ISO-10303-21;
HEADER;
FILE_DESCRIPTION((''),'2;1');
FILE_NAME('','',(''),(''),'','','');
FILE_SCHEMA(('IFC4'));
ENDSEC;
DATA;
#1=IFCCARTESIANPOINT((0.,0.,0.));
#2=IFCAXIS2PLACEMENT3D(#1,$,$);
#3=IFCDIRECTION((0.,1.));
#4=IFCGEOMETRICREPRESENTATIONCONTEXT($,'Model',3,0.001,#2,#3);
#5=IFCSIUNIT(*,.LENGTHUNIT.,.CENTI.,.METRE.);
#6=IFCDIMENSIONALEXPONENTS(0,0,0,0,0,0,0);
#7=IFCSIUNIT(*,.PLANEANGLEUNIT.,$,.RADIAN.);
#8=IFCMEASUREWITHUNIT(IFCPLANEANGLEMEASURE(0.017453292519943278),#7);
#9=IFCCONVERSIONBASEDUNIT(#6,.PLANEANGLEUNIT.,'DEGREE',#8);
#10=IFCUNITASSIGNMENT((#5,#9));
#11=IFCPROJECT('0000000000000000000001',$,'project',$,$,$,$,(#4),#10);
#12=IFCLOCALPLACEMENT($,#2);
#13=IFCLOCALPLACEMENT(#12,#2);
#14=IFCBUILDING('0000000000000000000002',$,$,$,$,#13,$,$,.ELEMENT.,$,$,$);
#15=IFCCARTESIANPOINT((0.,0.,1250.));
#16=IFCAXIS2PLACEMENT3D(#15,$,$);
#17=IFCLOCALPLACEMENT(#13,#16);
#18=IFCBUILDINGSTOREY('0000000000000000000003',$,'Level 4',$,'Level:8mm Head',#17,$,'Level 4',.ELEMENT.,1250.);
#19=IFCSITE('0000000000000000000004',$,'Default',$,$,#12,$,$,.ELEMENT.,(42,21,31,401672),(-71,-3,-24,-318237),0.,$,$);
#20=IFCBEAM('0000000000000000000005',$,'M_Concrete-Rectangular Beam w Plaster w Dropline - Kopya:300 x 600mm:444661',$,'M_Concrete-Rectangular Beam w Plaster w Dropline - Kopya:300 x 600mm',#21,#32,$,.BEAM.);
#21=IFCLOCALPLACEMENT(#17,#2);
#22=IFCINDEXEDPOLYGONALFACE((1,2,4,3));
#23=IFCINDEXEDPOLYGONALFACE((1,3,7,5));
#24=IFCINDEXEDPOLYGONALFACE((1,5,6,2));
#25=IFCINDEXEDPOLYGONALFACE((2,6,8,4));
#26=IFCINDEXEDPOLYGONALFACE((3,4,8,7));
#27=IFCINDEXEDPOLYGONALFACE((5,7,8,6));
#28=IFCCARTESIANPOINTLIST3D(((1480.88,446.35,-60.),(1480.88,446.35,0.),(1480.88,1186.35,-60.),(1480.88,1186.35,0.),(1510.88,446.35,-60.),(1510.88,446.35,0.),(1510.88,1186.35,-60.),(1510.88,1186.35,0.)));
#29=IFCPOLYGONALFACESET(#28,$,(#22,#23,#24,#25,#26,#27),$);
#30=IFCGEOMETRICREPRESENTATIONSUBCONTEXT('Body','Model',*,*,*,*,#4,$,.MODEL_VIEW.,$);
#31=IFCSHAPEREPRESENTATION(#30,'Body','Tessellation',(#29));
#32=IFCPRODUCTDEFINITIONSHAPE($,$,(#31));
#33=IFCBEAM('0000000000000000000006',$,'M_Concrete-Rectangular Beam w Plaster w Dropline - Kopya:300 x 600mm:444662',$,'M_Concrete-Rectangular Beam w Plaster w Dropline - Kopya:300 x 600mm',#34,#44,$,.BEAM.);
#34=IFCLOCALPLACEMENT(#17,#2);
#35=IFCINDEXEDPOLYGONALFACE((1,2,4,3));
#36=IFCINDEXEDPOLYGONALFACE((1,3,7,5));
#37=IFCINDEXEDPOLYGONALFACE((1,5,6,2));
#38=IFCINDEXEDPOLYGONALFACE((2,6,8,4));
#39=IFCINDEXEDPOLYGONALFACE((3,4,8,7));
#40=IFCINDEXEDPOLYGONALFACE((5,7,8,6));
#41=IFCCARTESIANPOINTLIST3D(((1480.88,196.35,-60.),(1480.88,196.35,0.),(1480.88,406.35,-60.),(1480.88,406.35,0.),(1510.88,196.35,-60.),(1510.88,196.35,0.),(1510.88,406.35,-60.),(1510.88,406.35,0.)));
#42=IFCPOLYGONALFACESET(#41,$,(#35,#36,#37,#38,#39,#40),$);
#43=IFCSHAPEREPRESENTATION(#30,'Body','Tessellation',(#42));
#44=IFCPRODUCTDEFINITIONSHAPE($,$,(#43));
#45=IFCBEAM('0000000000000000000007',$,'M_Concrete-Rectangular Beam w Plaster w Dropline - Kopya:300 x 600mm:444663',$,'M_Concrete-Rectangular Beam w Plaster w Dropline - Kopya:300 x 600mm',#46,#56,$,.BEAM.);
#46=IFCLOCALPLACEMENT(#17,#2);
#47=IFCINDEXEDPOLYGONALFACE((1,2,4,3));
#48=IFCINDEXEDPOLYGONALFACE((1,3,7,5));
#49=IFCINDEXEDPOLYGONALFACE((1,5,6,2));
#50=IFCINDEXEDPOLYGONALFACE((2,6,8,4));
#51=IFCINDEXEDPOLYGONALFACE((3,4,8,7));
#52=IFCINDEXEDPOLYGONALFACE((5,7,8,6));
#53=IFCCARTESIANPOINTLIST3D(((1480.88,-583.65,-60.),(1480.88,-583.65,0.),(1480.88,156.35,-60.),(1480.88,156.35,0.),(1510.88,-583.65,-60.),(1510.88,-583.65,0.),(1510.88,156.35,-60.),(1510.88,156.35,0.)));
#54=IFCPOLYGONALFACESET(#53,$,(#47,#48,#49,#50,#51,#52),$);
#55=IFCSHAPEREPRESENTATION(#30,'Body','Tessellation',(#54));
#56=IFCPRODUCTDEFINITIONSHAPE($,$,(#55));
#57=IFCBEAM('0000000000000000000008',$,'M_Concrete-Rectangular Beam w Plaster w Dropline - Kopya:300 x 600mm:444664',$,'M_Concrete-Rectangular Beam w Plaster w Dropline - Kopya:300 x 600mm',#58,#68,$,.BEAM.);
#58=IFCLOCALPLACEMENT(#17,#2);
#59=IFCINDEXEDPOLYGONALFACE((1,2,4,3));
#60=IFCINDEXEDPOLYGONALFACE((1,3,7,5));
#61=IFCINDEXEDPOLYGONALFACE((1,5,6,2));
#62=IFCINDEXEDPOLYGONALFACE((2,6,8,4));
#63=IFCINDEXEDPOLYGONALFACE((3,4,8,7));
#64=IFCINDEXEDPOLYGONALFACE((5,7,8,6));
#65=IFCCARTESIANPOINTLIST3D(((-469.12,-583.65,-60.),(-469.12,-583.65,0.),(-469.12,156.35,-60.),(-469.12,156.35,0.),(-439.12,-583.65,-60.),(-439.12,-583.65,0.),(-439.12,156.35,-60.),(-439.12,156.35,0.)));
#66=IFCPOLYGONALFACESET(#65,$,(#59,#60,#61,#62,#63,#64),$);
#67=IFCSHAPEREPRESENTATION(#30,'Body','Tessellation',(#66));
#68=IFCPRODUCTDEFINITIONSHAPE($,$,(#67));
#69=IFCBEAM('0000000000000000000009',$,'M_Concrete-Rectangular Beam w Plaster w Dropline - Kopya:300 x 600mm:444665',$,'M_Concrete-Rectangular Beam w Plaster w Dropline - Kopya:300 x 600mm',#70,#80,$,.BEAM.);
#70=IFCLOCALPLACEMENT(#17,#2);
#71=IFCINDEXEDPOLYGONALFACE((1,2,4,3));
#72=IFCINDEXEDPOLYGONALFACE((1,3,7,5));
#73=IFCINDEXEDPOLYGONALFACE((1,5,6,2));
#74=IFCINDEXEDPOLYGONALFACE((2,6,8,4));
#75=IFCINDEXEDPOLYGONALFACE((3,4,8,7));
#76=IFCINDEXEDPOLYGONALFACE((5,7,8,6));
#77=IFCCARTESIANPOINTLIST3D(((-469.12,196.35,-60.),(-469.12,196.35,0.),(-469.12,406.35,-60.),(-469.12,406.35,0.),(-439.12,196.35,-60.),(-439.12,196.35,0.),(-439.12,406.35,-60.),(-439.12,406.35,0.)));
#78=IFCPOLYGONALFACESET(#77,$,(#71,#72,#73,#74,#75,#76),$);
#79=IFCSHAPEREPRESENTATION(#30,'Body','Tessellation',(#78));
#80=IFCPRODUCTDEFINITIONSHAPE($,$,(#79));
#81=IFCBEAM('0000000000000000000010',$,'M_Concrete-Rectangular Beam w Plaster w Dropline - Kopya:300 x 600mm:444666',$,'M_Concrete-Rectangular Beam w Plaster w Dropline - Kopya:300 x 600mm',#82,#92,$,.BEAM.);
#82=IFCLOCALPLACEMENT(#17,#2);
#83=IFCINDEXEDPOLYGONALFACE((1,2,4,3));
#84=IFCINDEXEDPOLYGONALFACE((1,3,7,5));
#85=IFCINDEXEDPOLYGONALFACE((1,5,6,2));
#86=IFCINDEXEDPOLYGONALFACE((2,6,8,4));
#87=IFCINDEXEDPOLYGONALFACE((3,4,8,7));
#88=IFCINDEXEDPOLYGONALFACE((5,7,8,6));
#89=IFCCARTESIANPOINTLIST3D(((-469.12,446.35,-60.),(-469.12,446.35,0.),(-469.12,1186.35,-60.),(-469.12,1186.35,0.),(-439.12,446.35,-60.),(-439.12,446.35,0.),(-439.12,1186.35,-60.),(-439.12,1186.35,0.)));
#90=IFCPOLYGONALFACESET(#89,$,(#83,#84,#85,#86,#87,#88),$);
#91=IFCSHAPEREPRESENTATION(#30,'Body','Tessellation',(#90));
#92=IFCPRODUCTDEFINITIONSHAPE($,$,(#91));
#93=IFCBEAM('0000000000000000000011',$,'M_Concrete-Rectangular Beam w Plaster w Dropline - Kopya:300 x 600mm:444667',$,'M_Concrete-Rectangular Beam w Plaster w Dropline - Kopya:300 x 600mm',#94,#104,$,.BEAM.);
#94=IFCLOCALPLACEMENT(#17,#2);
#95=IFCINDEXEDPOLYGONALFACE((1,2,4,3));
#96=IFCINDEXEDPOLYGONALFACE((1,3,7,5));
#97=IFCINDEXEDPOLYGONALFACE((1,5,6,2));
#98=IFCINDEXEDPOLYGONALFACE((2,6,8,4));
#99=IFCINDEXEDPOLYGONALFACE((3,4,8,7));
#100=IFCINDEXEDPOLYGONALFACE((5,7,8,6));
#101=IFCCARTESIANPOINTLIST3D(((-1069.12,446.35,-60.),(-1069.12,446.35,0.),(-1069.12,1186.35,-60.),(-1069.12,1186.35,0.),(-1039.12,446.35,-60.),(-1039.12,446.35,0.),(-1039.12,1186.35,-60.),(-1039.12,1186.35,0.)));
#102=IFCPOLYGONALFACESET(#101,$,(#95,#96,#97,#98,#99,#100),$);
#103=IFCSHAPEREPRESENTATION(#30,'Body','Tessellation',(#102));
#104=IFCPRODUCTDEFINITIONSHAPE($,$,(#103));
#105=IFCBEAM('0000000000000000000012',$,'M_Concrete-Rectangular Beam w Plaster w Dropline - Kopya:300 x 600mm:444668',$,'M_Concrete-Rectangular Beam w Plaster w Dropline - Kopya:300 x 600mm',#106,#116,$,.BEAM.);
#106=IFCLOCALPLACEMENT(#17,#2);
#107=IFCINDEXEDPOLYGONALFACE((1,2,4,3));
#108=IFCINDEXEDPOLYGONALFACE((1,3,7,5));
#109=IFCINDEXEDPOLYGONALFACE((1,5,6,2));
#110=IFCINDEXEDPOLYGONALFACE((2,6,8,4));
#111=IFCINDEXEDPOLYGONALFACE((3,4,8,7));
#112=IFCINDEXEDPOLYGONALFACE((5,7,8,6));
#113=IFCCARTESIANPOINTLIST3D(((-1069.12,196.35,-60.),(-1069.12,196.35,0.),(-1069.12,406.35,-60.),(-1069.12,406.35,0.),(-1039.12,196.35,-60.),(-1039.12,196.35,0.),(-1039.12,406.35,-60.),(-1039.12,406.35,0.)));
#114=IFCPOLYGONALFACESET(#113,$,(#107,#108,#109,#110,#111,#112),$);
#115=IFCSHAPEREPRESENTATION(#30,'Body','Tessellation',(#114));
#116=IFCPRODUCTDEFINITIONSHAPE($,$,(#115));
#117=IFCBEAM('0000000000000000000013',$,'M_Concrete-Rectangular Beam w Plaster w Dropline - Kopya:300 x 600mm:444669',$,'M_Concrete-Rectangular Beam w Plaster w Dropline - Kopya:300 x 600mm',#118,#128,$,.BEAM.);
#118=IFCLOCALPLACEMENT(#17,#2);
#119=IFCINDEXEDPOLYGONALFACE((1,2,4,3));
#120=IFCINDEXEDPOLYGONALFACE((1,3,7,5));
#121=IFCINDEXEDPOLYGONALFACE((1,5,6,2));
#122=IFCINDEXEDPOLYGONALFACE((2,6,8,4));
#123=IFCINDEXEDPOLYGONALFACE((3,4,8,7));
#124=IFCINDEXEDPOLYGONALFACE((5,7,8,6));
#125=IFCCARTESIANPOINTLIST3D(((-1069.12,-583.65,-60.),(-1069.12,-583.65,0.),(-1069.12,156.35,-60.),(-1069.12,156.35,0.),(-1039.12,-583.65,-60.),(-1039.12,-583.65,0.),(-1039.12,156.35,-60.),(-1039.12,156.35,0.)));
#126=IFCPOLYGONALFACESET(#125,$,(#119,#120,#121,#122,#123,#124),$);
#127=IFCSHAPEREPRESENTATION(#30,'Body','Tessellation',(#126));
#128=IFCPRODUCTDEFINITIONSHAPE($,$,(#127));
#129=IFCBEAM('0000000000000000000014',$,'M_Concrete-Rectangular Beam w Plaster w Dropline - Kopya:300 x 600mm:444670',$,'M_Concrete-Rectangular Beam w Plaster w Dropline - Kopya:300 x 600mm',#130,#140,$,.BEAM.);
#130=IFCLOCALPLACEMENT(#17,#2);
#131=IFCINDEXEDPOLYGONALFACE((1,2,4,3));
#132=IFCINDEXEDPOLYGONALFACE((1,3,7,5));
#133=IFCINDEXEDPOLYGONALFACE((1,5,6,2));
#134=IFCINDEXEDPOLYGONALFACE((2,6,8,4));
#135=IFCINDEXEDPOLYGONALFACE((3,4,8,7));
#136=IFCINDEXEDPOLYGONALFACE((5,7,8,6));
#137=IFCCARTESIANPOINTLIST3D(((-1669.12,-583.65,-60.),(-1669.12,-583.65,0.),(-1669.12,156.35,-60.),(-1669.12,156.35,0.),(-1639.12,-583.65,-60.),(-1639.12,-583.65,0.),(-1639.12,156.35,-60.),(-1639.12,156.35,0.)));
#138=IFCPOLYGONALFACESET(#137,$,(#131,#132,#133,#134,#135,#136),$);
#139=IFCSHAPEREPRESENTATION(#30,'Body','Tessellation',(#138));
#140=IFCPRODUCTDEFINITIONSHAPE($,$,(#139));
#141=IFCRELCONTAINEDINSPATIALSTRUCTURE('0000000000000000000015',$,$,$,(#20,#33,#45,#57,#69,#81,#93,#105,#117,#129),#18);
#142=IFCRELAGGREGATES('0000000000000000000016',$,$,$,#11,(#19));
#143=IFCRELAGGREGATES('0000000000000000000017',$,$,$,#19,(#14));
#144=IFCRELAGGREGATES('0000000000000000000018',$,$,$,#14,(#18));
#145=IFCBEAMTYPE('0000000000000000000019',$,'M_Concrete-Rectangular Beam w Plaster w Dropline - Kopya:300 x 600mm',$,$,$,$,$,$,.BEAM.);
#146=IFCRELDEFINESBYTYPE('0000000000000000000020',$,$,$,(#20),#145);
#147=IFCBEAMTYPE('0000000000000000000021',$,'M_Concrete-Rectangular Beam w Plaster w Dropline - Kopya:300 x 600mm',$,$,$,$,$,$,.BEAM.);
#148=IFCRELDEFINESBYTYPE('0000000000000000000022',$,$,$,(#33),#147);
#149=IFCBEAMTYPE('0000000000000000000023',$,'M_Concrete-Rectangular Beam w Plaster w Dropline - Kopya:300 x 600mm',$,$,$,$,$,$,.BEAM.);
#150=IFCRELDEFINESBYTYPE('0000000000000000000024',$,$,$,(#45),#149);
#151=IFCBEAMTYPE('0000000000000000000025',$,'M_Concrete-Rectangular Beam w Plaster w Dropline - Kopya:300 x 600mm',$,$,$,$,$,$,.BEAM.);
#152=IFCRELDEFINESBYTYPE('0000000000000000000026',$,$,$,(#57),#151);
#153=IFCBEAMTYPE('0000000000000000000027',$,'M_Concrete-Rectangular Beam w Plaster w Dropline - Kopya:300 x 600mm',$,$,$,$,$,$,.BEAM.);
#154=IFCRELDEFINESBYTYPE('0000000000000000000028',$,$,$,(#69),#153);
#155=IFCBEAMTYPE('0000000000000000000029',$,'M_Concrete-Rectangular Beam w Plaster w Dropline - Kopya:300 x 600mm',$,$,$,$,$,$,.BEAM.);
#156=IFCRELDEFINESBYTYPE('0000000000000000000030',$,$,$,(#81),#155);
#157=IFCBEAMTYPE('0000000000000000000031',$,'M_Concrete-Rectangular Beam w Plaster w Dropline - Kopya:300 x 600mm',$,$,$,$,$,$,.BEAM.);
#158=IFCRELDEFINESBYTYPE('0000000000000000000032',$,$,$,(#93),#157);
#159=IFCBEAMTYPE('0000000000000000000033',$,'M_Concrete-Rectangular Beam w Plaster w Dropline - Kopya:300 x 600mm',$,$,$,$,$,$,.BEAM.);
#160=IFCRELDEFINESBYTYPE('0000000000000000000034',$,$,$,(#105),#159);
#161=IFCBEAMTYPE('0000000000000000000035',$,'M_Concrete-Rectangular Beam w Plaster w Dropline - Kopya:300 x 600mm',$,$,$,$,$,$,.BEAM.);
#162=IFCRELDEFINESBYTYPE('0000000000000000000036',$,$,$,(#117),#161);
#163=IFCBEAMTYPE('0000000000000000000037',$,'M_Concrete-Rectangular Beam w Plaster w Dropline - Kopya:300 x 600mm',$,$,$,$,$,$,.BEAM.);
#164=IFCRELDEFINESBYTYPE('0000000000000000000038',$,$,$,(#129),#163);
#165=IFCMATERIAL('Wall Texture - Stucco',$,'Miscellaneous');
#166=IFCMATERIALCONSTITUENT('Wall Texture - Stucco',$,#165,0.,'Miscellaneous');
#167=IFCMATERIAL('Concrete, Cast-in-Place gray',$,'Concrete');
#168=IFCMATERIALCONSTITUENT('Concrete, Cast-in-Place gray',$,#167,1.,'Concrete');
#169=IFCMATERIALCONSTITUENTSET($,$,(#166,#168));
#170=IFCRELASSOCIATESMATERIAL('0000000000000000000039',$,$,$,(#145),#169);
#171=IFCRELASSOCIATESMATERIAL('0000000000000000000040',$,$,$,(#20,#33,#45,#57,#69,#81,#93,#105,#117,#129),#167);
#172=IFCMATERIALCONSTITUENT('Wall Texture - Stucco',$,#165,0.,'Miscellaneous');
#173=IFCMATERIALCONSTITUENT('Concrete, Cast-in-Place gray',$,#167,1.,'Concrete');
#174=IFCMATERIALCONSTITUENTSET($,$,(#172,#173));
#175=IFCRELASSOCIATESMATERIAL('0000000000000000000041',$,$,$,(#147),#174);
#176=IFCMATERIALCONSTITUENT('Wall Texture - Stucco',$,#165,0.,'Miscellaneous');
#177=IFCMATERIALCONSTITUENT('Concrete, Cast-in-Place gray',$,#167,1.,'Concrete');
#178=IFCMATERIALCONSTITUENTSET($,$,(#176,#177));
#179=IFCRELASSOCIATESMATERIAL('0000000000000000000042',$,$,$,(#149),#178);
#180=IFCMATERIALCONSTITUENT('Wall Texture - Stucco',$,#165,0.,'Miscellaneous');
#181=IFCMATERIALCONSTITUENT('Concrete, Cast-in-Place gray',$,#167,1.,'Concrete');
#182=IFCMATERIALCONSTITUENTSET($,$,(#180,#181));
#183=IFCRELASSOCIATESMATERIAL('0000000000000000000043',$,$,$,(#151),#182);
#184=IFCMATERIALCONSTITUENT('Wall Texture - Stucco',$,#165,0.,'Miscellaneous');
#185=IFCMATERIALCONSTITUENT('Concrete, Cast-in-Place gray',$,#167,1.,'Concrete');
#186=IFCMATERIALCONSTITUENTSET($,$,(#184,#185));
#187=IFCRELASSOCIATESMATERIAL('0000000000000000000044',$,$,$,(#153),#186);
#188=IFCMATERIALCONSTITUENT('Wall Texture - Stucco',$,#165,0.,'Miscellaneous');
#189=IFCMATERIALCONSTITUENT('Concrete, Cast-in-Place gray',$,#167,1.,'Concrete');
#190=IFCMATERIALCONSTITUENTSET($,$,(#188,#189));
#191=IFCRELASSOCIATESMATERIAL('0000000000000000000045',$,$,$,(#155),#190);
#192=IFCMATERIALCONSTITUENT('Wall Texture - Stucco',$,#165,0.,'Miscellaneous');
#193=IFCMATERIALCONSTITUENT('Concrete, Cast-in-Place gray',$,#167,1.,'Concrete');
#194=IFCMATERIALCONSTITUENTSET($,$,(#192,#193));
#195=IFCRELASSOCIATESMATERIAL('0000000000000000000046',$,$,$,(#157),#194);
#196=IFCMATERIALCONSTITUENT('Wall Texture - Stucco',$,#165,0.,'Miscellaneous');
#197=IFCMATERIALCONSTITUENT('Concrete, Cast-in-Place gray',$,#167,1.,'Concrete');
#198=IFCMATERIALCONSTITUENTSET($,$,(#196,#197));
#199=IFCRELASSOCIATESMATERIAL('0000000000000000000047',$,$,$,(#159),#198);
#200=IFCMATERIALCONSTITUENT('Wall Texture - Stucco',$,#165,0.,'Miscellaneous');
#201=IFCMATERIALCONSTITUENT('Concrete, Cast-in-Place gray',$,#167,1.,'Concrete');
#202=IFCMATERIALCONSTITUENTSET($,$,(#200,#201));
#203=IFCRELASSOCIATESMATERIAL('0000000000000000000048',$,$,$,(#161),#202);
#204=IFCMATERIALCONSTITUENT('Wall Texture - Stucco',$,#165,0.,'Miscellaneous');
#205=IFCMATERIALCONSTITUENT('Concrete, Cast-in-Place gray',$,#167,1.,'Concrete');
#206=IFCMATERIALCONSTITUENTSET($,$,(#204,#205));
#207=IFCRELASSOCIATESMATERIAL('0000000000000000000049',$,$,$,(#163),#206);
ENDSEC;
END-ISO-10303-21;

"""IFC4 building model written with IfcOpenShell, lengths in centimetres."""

from ifc_helpers import new_model, entity, si_unit, converted_unit, direction, frame, origin, place, context, subcontext, project, spatial, indexed_curve, outline, extrude, source, transform, mapped, material, constituent, constituent_set, type_object, type_shapes, element, save


model = new_model("IFC4")

# Units and contexts
model_context = context("Model", 3, precision=0.001, world=origin(), true_north=direction((0.0, 1.0)))
body_context = subcontext(model_context, "Body", "Model", "MODEL_VIEW")
ifc_project = project(units=[si_unit("LENGTHUNIT", "METRE", prefix="CENTI"), converted_unit("PLANEANGLEUNIT", "DEGREE", entity("IfcPlaneAngleMeasure", 0.017453292519943278), si_unit("PLANEANGLEUNIT", "RADIAN"), dimensions=[0, 0, 0, 0, 0, 0, 0])], contexts=[model_context])

# Site, building, storey
site_placement = place(None, origin())
site = spatial("IfcSite", under=ifc_project, at=site_placement, Name="Default", CompositionType="ELEMENT", RefLatitude=(42, 21, 31, 401672), RefLongitude=(-71, -3, -24, -318237), RefElevation=0.0)
building_placement = place(site_placement, origin())
building = spatial("IfcBuilding", under=site, at=building_placement, CompositionType="ELEMENT")
storey_placement = place(building_placement, frame((0.0, 0.0, 1250.0)))
storey = spatial("IfcBuildingStorey", under=building, at=storey_placement, Name="Level 4", ObjectType="Level:8mm Head", LongName="Level 4", CompositionType="ELEMENT", Elevation=1250.0)

# Shared definitions
ifc_material_1 = material(Name="Concrete, Cast-in-Place gray", Category="Concrete")

# Beams
ifc_material_2 = material(Name="Wall Texture - Stucco", Category="Miscellaneous")
ifc_constituent_1 = constituent(ifc_material_2, Name="Wall Texture - Stucco", Category="Miscellaneous", fraction=0.0)
ifc_constituent_2 = constituent(ifc_material_1, Name="Concrete, Cast-in-Place gray", Category="Concrete", fraction=1.0)
ifc_constituent_set_1 = constituent_set(constituents=[ifc_constituent_1, ifc_constituent_2])
beam_type_1 = type_object("IfcBeamType", Name="M_Concrete-Rectangular Beam w Plaster w Dropline - Kopya:300 x 600mm", PredefinedType="BEAM", material=ifc_constituent_set_1)
shared_shape_1 = source(origin(), body_context, "Body", "SweptSolid", [
    extrude(outline(indexed_curve([(-15.0, -30.0), (15.0, -30.0), (15.0, 30.0), (-15.0, 30.0), (-15.0, -30.0)], self_intersect=False)), frame((1495.88, 1186.35, 1220.0), z_axis=(0.0, -1.0, 0.0), x_axis=(-1.0, 0.0, 0.0)), (0.0, 0.0, 1.0), 740.0),
])
type_shapes(beam_type_1, [shared_shape_1])
beam_1_placement = place(storey_placement, frame((0.0, 0.0, -1250.0)))
element("IfcBeam", 1, at=beam_1_placement, inside=storey, type_object=beam_type_1, material=ifc_material_1, Name="M_Concrete-Rectangular Beam w Plaster w Dropline - Kopya:300 x 600mm:444661", ObjectType="M_Concrete-Rectangular Beam w Plaster w Dropline - Kopya:300 x 600mm", PredefinedType="BEAM", context=body_context, shape_type="MappedRepresentation", body=[
    mapped(shared_shape_1, transform((0.0, 0.0, 0.0), scale=1.0)),
])
ifc_constituent_3 = constituent(ifc_material_2, Name="Wall Texture - Stucco", Category="Miscellaneous", fraction=0.0)
ifc_constituent_4 = constituent(ifc_material_1, Name="Concrete, Cast-in-Place gray", Category="Concrete", fraction=1.0)
ifc_constituent_set_2 = constituent_set(constituents=[ifc_constituent_3, ifc_constituent_4])
beam_type_2 = type_object("IfcBeamType", Name="M_Concrete-Rectangular Beam w Plaster w Dropline - Kopya:300 x 600mm", PredefinedType="BEAM", material=ifc_constituent_set_2)
shared_shape_2 = source(origin(), body_context, "Body", "SweptSolid", [
    extrude(outline(indexed_curve([(-15.0, -30.0), (15.0, -30.0), (15.0, 30.0), (-15.0, 30.0), (-15.0, -30.0)], self_intersect=False)), frame((1495.88, 406.35, 1220.0), z_axis=(0.0, -1.0, 0.0), x_axis=(-1.0, 0.0, 0.0)), (0.0, 0.0, 1.0), 210.0),
])
type_shapes(beam_type_2, [shared_shape_2])
beam_2_placement = place(storey_placement, frame((0.0, 0.0, -1250.0)))
element("IfcBeam", 2, at=beam_2_placement, inside=storey, type_object=beam_type_2, material=ifc_material_1, Name="M_Concrete-Rectangular Beam w Plaster w Dropline - Kopya:300 x 600mm:444662", ObjectType="M_Concrete-Rectangular Beam w Plaster w Dropline - Kopya:300 x 600mm", PredefinedType="BEAM", context=body_context, shape_type="MappedRepresentation", body=[
    mapped(shared_shape_2, transform((0.0, 0.0, 0.0), scale=1.0)),
])
ifc_constituent_5 = constituent(ifc_material_2, Name="Wall Texture - Stucco", Category="Miscellaneous", fraction=0.0)
ifc_constituent_6 = constituent(ifc_material_1, Name="Concrete, Cast-in-Place gray", Category="Concrete", fraction=1.0)
ifc_constituent_set_3 = constituent_set(constituents=[ifc_constituent_5, ifc_constituent_6])
beam_type_3 = type_object("IfcBeamType", Name="M_Concrete-Rectangular Beam w Plaster w Dropline - Kopya:300 x 600mm", PredefinedType="BEAM", material=ifc_constituent_set_3)
shared_shape_3 = source(origin(), body_context, "Body", "SweptSolid", [
    extrude(outline(indexed_curve([(-15.0, -30.0), (15.0, -30.0), (15.0, 30.0), (-15.0, 30.0), (-15.0, -30.0)], self_intersect=False)), frame((1495.88, 156.35, 1220.0), z_axis=(0.0, -1.0, 0.0), x_axis=(-1.0, 0.0, 0.0)), (0.0, 0.0, 1.0), 740.0),
])
type_shapes(beam_type_3, [shared_shape_3])
beam_3_placement = place(storey_placement, frame((0.0, 0.0, -1250.0)))
element("IfcBeam", 3, at=beam_3_placement, inside=storey, type_object=beam_type_3, material=ifc_material_1, Name="M_Concrete-Rectangular Beam w Plaster w Dropline - Kopya:300 x 600mm:444663", ObjectType="M_Concrete-Rectangular Beam w Plaster w Dropline - Kopya:300 x 600mm", PredefinedType="BEAM", context=body_context, shape_type="MappedRepresentation", body=[
    mapped(shared_shape_3, transform((0.0, 0.0, 0.0), scale=1.0)),
])
ifc_constituent_7 = constituent(ifc_material_2, Name="Wall Texture - Stucco", Category="Miscellaneous", fraction=0.0)
ifc_constituent_8 = constituent(ifc_material_1, Name="Concrete, Cast-in-Place gray", Category="Concrete", fraction=1.0)
ifc_constituent_set_4 = constituent_set(constituents=[ifc_constituent_7, ifc_constituent_8])
beam_type_4 = type_object("IfcBeamType", Name="M_Concrete-Rectangular Beam w Plaster w Dropline - Kopya:300 x 600mm", PredefinedType="BEAM", material=ifc_constituent_set_4)
shared_shape_4 = source(origin(), body_context, "Body", "SweptSolid", [
    extrude(outline(indexed_curve([(-15.0, -30.0), (15.0, -30.0), (15.0, 30.0), (-15.0, 30.0), (-15.0, -30.0)], self_intersect=False)), frame((-454.12, -583.65, 1220.0), z_axis=(0.0, 1.0, 0.0), x_axis=(-1.0, 0.0, 0.0)), (0.0, 0.0, 1.0), 740.0),
])
type_shapes(beam_type_4, [shared_shape_4])
beam_4_placement = place(storey_placement, frame((0.0, 0.0, -1250.0)))
element("IfcBeam", 4, at=beam_4_placement, inside=storey, type_object=beam_type_4, material=ifc_material_1, Name="M_Concrete-Rectangular Beam w Plaster w Dropline - Kopya:300 x 600mm:444664", ObjectType="M_Concrete-Rectangular Beam w Plaster w Dropline - Kopya:300 x 600mm", PredefinedType="BEAM", context=body_context, shape_type="MappedRepresentation", body=[
    mapped(shared_shape_4, transform((0.0, 0.0, 0.0), scale=1.0)),
])
ifc_constituent_9 = constituent(ifc_material_2, Name="Wall Texture - Stucco", Category="Miscellaneous", fraction=0.0)
ifc_constituent_10 = constituent(ifc_material_1, Name="Concrete, Cast-in-Place gray", Category="Concrete", fraction=1.0)
ifc_constituent_set_5 = constituent_set(constituents=[ifc_constituent_9, ifc_constituent_10])
beam_type_5 = type_object("IfcBeamType", Name="M_Concrete-Rectangular Beam w Plaster w Dropline - Kopya:300 x 600mm", PredefinedType="BEAM", material=ifc_constituent_set_5)
shared_shape_5 = source(origin(), body_context, "Body", "SweptSolid", [
    extrude(outline(indexed_curve([(-15.0, -30.0), (15.0, -30.0), (15.0, 30.0), (-15.0, 30.0), (-15.0, -30.0)], self_intersect=False)), frame((-454.12, 196.35, 1220.0), z_axis=(0.0, 1.0, 0.0), x_axis=(-1.0, 0.0, 0.0)), (0.0, 0.0, 1.0), 210.0),
])
type_shapes(beam_type_5, [shared_shape_5])
beam_5_placement = place(storey_placement, frame((0.0, 0.0, -1250.0)))
element("IfcBeam", 5, at=beam_5_placement, inside=storey, type_object=beam_type_5, material=ifc_material_1, Name="M_Concrete-Rectangular Beam w Plaster w Dropline - Kopya:300 x 600mm:444665", ObjectType="M_Concrete-Rectangular Beam w Plaster w Dropline - Kopya:300 x 600mm", PredefinedType="BEAM", context=body_context, shape_type="MappedRepresentation", body=[
    mapped(shared_shape_5, transform((0.0, 0.0, 0.0), scale=1.0)),
])
ifc_constituent_11 = constituent(ifc_material_2, Name="Wall Texture - Stucco", Category="Miscellaneous", fraction=0.0)
ifc_constituent_12 = constituent(ifc_material_1, Name="Concrete, Cast-in-Place gray", Category="Concrete", fraction=1.0)
ifc_constituent_set_6 = constituent_set(constituents=[ifc_constituent_11, ifc_constituent_12])
beam_type_6 = type_object("IfcBeamType", Name="M_Concrete-Rectangular Beam w Plaster w Dropline - Kopya:300 x 600mm", PredefinedType="BEAM", material=ifc_constituent_set_6)
shared_shape_6 = source(origin(), body_context, "Body", "SweptSolid", [
    extrude(outline(indexed_curve([(-15.0, -30.0), (15.0, -30.0), (15.0, 30.0), (-15.0, 30.0), (-15.0, -30.0)], self_intersect=False)), frame((-454.12, 446.35, 1220.0), z_axis=(0.0, 1.0, 0.0), x_axis=(-1.0, 0.0, 0.0)), (0.0, 0.0, 1.0), 740.0),
])
type_shapes(beam_type_6, [shared_shape_6])
beam_6_placement = place(storey_placement, frame((0.0, 0.0, -1250.0)))
element("IfcBeam", 6, at=beam_6_placement, inside=storey, type_object=beam_type_6, material=ifc_material_1, Name="M_Concrete-Rectangular Beam w Plaster w Dropline - Kopya:300 x 600mm:444666", ObjectType="M_Concrete-Rectangular Beam w Plaster w Dropline - Kopya:300 x 600mm", PredefinedType="BEAM", context=body_context, shape_type="MappedRepresentation", body=[
    mapped(shared_shape_6, transform((0.0, 0.0, 0.0), scale=1.0)),
])
ifc_constituent_13 = constituent(ifc_material_2, Name="Wall Texture - Stucco", Category="Miscellaneous", fraction=0.0)
ifc_constituent_14 = constituent(ifc_material_1, Name="Concrete, Cast-in-Place gray", Category="Concrete", fraction=1.0)
ifc_constituent_set_7 = constituent_set(constituents=[ifc_constituent_13, ifc_constituent_14])
beam_type_7 = type_object("IfcBeamType", Name="M_Concrete-Rectangular Beam w Plaster w Dropline - Kopya:300 x 600mm", PredefinedType="BEAM", material=ifc_constituent_set_7)
shared_shape_7 = source(origin(), body_context, "Body", "SweptSolid", [
    extrude(outline(indexed_curve([(-15.0, -30.0), (15.0, -30.0), (15.0, 30.0), (-15.0, 30.0), (-15.0, -30.0)], self_intersect=False)), frame((-1054.12, 1186.35, 1220.0), z_axis=(0.0, -1.0, 0.0), x_axis=(-1.0, 0.0, 0.0)), (0.0, 0.0, 1.0), 740.0),
])
type_shapes(beam_type_7, [shared_shape_7])
beam_7_placement = place(storey_placement, frame((0.0, 0.0, -1250.0)))
element("IfcBeam", 7, at=beam_7_placement, inside=storey, type_object=beam_type_7, material=ifc_material_1, Name="M_Concrete-Rectangular Beam w Plaster w Dropline - Kopya:300 x 600mm:444667", ObjectType="M_Concrete-Rectangular Beam w Plaster w Dropline - Kopya:300 x 600mm", PredefinedType="BEAM", context=body_context, shape_type="MappedRepresentation", body=[
    mapped(shared_shape_7, transform((0.0, 0.0, 0.0), scale=1.0)),
])
ifc_constituent_15 = constituent(ifc_material_2, Name="Wall Texture - Stucco", Category="Miscellaneous", fraction=0.0)
ifc_constituent_16 = constituent(ifc_material_1, Name="Concrete, Cast-in-Place gray", Category="Concrete", fraction=1.0)
ifc_constituent_set_8 = constituent_set(constituents=[ifc_constituent_15, ifc_constituent_16])
beam_type_8 = type_object("IfcBeamType", Name="M_Concrete-Rectangular Beam w Plaster w Dropline - Kopya:300 x 600mm", PredefinedType="BEAM", material=ifc_constituent_set_8)
shared_shape_8 = source(origin(), body_context, "Body", "SweptSolid", [
    extrude(outline(indexed_curve([(-15.0, -30.0), (15.0, -30.0), (15.0, 30.0), (-15.0, 30.0), (-15.0, -30.0)], self_intersect=False)), frame((-1054.12, 406.35, 1220.0), z_axis=(0.0, -1.0, 0.0), x_axis=(-1.0, 0.0, 0.0)), (0.0, 0.0, 1.0), 210.0),
])
type_shapes(beam_type_8, [shared_shape_8])
beam_8_placement = place(storey_placement, frame((0.0, 0.0, -1250.0)))
element("IfcBeam", 8, at=beam_8_placement, inside=storey, type_object=beam_type_8, material=ifc_material_1, Name="M_Concrete-Rectangular Beam w Plaster w Dropline - Kopya:300 x 600mm:444668", ObjectType="M_Concrete-Rectangular Beam w Plaster w Dropline - Kopya:300 x 600mm", PredefinedType="BEAM", context=body_context, shape_type="MappedRepresentation", body=[
    mapped(shared_shape_8, transform((0.0, 0.0, 0.0), scale=1.0)),
])
ifc_constituent_17 = constituent(ifc_material_2, Name="Wall Texture - Stucco", Category="Miscellaneous", fraction=0.0)
ifc_constituent_18 = constituent(ifc_material_1, Name="Concrete, Cast-in-Place gray", Category="Concrete", fraction=1.0)
ifc_constituent_set_9 = constituent_set(constituents=[ifc_constituent_17, ifc_constituent_18])
beam_type_9 = type_object("IfcBeamType", Name="M_Concrete-Rectangular Beam w Plaster w Dropline - Kopya:300 x 600mm", PredefinedType="BEAM", material=ifc_constituent_set_9)
shared_shape_9 = source(origin(), body_context, "Body", "SweptSolid", [
    extrude(outline(indexed_curve([(-15.0, -30.0), (15.0, -30.0), (15.0, 30.0), (-15.0, 30.0), (-15.0, -30.0)], self_intersect=False)), frame((-1054.12, 156.35, 1220.0), z_axis=(0.0, -1.0, 0.0), x_axis=(-1.0, 0.0, 0.0)), (0.0, 0.0, 1.0), 740.0),
])
type_shapes(beam_type_9, [shared_shape_9])
beam_9_placement = place(storey_placement, frame((0.0, 0.0, -1250.0)))
element("IfcBeam", 9, at=beam_9_placement, inside=storey, type_object=beam_type_9, material=ifc_material_1, Name="M_Concrete-Rectangular Beam w Plaster w Dropline - Kopya:300 x 600mm:444669", ObjectType="M_Concrete-Rectangular Beam w Plaster w Dropline - Kopya:300 x 600mm", PredefinedType="BEAM", context=body_context, shape_type="MappedRepresentation", body=[
    mapped(shared_shape_9, transform((0.0, 0.0, 0.0), scale=1.0)),
])
ifc_constituent_19 = constituent(ifc_material_2, Name="Wall Texture - Stucco", Category="Miscellaneous", fraction=0.0)
ifc_constituent_20 = constituent(ifc_material_1, Name="Concrete, Cast-in-Place gray", Category="Concrete", fraction=1.0)
ifc_constituent_set_10 = constituent_set(constituents=[ifc_constituent_19, ifc_constituent_20])
beam_type_10 = type_object("IfcBeamType", Name="M_Concrete-Rectangular Beam w Plaster w Dropline - Kopya:300 x 600mm", PredefinedType="BEAM", material=ifc_constituent_set_10)
shared_shape_10 = source(origin(), body_context, "Body", "SweptSolid", [
    extrude(outline(indexed_curve([(-15.0, -30.0), (15.0, -30.0), (15.0, 30.0), (-15.0, 30.0), (-15.0, -30.0)], self_intersect=False)), frame((-1654.12, -583.65, 1220.0), z_axis=(0.0, 1.0, 0.0), x_axis=(-1.0, 0.0, 0.0)), (0.0, 0.0, 1.0), 740.0),
])
type_shapes(beam_type_10, [shared_shape_10])
beam_10_placement = place(storey_placement, frame((0.0, 0.0, -1250.0)))
element("IfcBeam", 10, at=beam_10_placement, inside=storey, type_object=beam_type_10, material=ifc_material_1, Name="M_Concrete-Rectangular Beam w Plaster w Dropline - Kopya:300 x 600mm:444670", ObjectType="M_Concrete-Rectangular Beam w Plaster w Dropline - Kopya:300 x 600mm", PredefinedType="BEAM", context=body_context, shape_type="MappedRepresentation", body=[
    mapped(shared_shape_10, transform((0.0, 0.0, 0.0), scale=1.0)),
])

save(model, "model.ifc")
